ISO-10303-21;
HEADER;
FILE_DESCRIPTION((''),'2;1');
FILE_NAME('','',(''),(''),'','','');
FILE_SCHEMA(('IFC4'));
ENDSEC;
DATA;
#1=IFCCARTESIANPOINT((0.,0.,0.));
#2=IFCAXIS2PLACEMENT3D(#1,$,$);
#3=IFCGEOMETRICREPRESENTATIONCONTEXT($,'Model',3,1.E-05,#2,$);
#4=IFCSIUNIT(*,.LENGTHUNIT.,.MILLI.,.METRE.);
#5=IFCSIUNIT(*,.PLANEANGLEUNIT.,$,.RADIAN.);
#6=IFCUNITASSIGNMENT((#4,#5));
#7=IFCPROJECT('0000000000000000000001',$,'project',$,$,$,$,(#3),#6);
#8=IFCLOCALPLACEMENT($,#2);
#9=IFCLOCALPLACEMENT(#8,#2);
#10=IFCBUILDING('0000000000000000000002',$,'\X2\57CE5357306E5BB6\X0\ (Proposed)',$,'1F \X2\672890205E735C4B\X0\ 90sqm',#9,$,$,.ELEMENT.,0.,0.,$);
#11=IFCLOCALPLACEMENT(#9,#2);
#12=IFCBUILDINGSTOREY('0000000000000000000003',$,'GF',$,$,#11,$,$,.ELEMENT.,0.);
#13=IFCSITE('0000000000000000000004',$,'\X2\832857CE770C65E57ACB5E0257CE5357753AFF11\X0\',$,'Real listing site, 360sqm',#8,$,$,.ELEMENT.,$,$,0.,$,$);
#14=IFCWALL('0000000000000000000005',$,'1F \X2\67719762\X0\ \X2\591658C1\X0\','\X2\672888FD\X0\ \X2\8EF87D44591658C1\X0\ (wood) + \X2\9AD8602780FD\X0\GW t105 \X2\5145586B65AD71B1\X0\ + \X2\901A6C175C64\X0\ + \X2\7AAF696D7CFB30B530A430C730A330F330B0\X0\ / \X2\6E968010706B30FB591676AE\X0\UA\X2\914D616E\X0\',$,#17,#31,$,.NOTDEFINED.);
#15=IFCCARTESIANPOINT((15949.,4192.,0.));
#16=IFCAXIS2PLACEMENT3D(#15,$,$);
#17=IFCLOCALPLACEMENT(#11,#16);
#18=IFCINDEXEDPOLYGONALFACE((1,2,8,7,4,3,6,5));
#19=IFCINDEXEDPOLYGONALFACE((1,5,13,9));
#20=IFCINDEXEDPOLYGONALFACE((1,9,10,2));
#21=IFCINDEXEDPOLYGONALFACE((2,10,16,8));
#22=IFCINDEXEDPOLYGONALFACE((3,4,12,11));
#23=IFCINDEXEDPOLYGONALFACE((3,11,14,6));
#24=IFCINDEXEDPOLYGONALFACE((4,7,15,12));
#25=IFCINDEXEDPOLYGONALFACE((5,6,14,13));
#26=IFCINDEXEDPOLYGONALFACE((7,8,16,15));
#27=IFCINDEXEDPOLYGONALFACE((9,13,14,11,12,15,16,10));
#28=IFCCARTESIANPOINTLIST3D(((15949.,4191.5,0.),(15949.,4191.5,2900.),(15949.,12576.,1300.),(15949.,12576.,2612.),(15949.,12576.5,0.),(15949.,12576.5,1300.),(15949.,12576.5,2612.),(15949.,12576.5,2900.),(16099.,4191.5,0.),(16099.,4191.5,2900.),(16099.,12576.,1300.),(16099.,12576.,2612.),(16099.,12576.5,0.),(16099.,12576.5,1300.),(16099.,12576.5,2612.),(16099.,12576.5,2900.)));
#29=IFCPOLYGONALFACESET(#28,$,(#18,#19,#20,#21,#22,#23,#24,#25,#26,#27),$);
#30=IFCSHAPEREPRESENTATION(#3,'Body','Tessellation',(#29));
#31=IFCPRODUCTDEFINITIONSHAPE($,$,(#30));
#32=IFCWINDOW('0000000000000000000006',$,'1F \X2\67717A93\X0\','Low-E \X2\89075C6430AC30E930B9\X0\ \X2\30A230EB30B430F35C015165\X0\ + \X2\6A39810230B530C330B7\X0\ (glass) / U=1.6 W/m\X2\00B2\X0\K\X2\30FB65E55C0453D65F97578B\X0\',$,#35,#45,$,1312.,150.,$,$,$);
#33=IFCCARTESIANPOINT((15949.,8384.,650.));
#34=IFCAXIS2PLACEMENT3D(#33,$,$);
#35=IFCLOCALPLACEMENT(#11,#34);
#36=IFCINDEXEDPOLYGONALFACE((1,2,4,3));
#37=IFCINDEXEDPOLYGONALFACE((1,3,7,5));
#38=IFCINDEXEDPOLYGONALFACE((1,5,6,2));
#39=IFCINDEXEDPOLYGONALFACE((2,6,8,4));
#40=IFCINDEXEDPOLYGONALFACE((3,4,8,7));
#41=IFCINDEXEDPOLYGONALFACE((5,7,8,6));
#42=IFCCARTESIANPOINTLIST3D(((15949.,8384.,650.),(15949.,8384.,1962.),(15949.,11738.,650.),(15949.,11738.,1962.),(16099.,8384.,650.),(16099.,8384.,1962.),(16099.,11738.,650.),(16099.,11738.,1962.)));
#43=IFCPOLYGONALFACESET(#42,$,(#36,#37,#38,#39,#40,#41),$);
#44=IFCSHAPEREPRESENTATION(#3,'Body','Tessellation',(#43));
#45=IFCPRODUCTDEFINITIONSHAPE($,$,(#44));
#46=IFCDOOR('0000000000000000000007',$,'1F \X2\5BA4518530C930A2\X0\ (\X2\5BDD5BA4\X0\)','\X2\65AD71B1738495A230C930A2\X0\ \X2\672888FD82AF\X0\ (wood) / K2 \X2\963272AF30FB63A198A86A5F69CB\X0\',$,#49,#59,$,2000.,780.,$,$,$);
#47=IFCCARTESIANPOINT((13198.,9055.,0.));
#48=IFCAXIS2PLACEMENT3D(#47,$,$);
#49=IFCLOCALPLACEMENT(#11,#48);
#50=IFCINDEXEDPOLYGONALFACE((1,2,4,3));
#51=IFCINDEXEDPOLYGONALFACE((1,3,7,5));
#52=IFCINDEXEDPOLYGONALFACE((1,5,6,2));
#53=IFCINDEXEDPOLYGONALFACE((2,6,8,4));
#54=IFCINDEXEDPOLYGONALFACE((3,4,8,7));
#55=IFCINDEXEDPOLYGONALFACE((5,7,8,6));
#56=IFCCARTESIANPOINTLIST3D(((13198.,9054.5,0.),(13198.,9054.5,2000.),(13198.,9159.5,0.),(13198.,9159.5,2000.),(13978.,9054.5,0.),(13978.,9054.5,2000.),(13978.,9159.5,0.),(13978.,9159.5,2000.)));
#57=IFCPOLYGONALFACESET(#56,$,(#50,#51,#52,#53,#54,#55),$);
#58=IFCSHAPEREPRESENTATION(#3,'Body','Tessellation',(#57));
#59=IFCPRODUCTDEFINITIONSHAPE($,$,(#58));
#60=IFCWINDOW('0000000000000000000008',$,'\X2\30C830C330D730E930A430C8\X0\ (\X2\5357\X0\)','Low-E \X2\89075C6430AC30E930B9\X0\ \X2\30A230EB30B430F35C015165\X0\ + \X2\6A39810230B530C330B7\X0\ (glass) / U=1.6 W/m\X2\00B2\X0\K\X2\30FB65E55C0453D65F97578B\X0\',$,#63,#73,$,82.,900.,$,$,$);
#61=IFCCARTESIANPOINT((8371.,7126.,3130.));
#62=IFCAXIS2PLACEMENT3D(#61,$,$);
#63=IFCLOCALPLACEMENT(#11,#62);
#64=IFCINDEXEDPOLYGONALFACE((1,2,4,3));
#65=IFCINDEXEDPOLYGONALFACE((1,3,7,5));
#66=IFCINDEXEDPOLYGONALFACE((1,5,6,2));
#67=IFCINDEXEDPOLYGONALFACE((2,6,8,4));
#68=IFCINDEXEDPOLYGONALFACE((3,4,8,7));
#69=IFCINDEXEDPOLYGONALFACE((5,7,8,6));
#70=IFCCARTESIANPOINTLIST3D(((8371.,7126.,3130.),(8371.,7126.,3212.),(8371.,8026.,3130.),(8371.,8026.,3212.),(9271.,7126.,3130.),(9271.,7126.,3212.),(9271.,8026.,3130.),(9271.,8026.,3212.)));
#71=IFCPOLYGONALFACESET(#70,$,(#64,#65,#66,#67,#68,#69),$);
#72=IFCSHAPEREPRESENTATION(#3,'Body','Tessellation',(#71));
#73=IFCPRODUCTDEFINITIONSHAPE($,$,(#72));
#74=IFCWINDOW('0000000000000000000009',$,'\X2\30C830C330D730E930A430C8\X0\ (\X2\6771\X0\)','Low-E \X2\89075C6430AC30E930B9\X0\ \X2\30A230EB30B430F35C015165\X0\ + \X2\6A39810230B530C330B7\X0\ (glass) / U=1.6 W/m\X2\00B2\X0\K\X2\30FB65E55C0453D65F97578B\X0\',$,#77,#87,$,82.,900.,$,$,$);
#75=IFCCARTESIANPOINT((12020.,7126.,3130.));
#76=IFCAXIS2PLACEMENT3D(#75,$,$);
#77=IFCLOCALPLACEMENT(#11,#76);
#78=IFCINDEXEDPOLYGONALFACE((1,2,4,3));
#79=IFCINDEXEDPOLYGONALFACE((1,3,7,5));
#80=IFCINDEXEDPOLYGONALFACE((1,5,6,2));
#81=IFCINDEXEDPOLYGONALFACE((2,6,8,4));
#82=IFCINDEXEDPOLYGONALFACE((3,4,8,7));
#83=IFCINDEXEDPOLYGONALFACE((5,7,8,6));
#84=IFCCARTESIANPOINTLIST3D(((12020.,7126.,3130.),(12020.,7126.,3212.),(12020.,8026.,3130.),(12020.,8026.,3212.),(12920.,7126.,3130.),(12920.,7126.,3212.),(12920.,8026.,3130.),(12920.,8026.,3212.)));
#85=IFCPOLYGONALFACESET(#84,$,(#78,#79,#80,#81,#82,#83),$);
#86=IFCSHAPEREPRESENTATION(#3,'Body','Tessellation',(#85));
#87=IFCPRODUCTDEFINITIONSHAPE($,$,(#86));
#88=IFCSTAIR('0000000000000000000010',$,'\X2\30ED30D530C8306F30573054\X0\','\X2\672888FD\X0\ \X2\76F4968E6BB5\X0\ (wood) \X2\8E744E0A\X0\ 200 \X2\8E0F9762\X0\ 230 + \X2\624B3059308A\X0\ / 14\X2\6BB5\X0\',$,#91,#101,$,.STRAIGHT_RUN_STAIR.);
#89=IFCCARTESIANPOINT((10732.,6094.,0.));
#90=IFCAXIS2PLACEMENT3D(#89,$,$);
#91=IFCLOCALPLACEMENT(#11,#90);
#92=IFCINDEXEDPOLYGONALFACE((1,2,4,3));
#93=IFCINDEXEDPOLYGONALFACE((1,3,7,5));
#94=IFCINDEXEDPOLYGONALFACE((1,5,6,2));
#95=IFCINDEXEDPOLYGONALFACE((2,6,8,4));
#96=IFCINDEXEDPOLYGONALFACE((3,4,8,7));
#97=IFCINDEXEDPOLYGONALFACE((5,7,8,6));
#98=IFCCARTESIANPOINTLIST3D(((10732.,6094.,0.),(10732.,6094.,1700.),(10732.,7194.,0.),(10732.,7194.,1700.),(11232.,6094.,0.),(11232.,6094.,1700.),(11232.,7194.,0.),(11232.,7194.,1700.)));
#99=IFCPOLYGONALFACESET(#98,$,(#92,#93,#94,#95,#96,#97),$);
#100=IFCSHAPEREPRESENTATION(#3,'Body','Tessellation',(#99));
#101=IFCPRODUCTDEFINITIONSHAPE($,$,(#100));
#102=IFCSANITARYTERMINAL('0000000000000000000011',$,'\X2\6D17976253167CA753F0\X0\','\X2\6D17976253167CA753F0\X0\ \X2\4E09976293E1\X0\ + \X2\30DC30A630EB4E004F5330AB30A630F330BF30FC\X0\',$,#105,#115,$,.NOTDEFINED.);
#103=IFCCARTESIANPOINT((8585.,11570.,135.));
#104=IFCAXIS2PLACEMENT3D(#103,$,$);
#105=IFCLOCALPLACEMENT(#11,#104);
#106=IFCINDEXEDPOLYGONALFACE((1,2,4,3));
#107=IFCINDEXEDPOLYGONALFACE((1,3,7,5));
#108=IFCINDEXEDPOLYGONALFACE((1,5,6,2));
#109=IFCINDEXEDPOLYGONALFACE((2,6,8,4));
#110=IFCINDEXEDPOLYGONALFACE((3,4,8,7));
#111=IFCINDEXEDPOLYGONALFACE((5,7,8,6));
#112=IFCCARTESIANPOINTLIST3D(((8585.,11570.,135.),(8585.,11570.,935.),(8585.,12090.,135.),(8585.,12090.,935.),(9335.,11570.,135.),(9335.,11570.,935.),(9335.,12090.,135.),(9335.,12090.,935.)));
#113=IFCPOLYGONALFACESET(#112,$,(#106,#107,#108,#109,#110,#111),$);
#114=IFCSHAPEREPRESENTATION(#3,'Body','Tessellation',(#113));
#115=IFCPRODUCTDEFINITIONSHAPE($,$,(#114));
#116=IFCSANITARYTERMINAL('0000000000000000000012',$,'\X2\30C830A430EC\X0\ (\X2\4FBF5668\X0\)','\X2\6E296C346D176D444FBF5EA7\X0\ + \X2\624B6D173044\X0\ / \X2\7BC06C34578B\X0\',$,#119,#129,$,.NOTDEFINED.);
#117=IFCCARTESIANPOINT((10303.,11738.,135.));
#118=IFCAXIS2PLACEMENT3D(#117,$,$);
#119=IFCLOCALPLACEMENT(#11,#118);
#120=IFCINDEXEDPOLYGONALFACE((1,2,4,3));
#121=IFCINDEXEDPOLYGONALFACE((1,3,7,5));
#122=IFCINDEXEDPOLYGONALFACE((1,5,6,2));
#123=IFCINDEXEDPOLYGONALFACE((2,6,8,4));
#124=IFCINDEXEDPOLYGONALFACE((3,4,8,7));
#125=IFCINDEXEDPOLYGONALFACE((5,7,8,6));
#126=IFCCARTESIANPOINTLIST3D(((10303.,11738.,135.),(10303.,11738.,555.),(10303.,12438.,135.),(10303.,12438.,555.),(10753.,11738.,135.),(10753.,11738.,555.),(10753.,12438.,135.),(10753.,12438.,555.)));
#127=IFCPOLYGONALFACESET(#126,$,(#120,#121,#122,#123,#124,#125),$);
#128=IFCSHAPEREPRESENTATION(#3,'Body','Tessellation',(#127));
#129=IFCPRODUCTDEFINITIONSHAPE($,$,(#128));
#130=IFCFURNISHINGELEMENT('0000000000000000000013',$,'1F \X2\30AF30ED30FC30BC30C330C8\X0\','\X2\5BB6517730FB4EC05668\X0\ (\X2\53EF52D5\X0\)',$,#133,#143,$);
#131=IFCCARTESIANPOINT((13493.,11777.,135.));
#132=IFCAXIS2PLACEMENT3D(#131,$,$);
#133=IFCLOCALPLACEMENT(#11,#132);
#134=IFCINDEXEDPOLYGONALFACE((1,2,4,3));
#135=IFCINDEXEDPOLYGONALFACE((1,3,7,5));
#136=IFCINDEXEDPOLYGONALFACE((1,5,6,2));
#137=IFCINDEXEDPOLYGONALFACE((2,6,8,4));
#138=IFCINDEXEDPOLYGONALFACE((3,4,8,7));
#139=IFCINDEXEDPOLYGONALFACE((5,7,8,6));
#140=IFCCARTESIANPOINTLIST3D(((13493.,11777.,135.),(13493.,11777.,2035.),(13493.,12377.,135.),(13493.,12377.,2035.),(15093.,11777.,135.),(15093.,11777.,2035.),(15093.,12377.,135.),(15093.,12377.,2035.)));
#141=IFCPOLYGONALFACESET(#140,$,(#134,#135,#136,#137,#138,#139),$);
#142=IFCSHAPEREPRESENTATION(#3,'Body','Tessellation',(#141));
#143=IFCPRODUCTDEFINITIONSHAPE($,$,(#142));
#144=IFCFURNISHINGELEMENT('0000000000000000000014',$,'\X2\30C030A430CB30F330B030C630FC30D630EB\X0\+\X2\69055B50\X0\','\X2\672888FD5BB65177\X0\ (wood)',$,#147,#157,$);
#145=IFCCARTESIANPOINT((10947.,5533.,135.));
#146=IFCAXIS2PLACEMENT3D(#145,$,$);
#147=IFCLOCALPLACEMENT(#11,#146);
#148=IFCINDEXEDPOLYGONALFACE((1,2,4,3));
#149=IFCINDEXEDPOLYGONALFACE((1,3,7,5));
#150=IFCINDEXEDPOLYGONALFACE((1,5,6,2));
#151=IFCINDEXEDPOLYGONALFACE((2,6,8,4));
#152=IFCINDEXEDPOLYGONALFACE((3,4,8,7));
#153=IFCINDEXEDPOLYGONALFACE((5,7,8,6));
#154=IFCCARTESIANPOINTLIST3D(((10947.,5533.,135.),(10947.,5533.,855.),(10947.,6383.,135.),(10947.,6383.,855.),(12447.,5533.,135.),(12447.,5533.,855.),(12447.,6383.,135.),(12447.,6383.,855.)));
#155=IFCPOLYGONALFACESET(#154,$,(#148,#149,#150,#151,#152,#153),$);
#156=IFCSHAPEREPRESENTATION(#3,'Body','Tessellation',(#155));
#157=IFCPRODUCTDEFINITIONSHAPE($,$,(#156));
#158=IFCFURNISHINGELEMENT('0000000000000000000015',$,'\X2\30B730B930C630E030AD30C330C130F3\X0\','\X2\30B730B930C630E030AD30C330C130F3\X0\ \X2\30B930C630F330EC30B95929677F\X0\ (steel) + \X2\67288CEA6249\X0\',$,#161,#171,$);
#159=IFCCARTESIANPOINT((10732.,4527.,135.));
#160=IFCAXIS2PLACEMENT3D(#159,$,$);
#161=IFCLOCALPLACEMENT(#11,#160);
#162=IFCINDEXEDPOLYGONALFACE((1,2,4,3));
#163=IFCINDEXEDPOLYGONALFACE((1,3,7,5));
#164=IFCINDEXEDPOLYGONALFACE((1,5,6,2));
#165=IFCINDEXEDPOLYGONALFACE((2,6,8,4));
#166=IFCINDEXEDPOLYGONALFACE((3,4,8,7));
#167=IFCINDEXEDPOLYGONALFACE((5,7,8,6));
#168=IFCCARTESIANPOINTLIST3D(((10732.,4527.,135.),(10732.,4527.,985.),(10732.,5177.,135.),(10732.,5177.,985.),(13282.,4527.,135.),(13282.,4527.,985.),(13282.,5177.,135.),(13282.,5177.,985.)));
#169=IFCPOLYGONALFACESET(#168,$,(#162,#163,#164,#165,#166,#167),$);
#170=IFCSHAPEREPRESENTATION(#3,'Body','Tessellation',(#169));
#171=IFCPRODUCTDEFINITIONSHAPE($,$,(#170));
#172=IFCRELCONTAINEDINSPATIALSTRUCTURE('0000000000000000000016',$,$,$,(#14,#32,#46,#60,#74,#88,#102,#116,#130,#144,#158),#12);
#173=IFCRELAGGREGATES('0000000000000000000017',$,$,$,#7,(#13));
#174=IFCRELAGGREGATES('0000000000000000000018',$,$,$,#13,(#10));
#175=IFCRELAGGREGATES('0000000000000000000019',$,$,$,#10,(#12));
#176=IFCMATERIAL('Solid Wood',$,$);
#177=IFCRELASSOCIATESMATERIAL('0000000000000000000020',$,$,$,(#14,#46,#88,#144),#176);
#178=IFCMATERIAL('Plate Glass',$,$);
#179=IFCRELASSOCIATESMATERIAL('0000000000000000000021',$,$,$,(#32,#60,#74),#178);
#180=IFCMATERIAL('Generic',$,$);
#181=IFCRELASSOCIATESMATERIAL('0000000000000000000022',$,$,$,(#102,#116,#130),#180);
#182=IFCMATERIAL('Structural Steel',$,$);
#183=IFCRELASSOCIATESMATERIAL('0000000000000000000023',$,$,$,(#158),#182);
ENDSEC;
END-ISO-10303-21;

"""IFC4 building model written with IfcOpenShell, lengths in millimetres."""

from ifc_helpers import new_model, si_unit, frame, frame_2d, origin, place, context, project, spatial, rectangle, extrude, material, element, fill, save


model = new_model("IFC4")

# Units and contexts
model_context = context("Model", 3, precision=1e-05, world=origin())
ifc_project = project(units=[si_unit("LENGTHUNIT", "METRE", prefix="MILLI"), si_unit("PLANEANGLEUNIT", "RADIAN")], contexts=[model_context])

# Site, building, storey
site_placement = place(None, origin())
site = spatial("IfcSite", under=ifc_project, at=site_placement, Name="茨城県日立市城南町１", ObjectType="Real listing site, 360sqm", CompositionType="ELEMENT", RefElevation=0.0)
building_placement = place(site_placement, origin())
building = spatial("IfcBuilding", under=site, at=building_placement, Name="城南の家 (Proposed)", ObjectType="1F 木造平屋 90sqm", CompositionType="ELEMENT", ElevationOfRefHeight=0.0, ElevationOfTerrain=0.0)
storey_placement = place(building_placement, origin())
storey = spatial("IfcBuildingStorey", under=building, at=storey_placement, Name="GF", CompositionType="ELEMENT", Elevation=0.0)

# Wall, opening, window
ifc_material_1 = material(Name="Solid Wood")
wall_1_placement = place(storey_placement, frame((15949.0, 4192.0, 0.0)))
wall_1 = element("IfcWall", 1, at=wall_1_placement, inside=storey, material=ifc_material_1, Name="1F 東面 外壁", Description="木製 軸組外壁 (wood) + 高性能GW t105 充填断熱 + 通気層 + 窯業系サイディング / 準耐火・外皮UA配慮", PredefinedType="NOTDEFINED", context=model_context, shape_type="SweptSolid", body=[
    extrude(rectangle(XDim=150.0, YDim=8385.0, at=frame_2d((75.0, 4192.0))), frame((15949.0, 4192.0, 0.0)), (0.0, 0.0, 1.0), 2900.0),
])
opening_placement = place(storey_placement, frame((15949.0, 8384.0, 650.0)))
opening = element("IfcOpeningElement", 2, at=opening_placement, cuts=wall_1, PredefinedType="NOTDEFINED", context=model_context, shape_type="SweptSolid", body=[
    extrude(rectangle(XDim=150.0, YDim=3354.0, at=frame_2d((75.0, 1677.0))), frame((15949.0, 8384.0, 650.0)), (0.0, 0.0, 1.0), 1312.0),
])
ifc_material_2 = material(Name="Plate Glass")
window_1_placement = place(storey_placement, frame((15949.0, 8384.0, 650.0)))
window_1 = element("IfcWindow", 3, at=window_1_placement, inside=storey, material=ifc_material_2, Name="1F 東窓", Description="Low-E 複層ガラス アルゴン封入 + 樹脂サッシ (glass) / U=1.6 W/m²K・日射取得型", OverallHeight=1312.0, OverallWidth=150.0, context=model_context, shape_type="SweptSolid", body=[
    extrude(rectangle(XDim=150.0, YDim=3354.0, at=frame_2d((75.0, 1677.0))), frame((15949.0, 8384.0, 650.0)), (0.0, 0.0, 1.0), 1312.0),
])
fill(opening, window_1)

# Door
door_placement = place(storey_placement, frame((13198.0, 9055.0, 0.0)))
element("IfcDoor", 4, at=door_placement, inside=storey, material=ifc_material_1, Name="1F 室内ドア (寝室)", Description="断熱玄関ドア 木製芯 (wood) / K2 防犯・採風機構", OverallHeight=2000.0, OverallWidth=780.0, context=model_context, shape_type="SweptSolid", body=[
    extrude(rectangle(XDim=780.0, YDim=105.0, at=frame_2d((390.0, 52.0))), frame((13198.0, 9055.0, 0.0)), (0.0, 0.0, 1.0), 2000.0),
])

# Windows
window_2_placement = place(storey_placement, frame((8371.0, 7126.0, 3130.0)))
element("IfcWindow", 5, at=window_2_placement, inside=storey, material=ifc_material_2, Name="トップライト (南)", Description="Low-E 複層ガラス アルゴン封入 + 樹脂サッシ (glass) / U=1.6 W/m²K・日射取得型", OverallHeight=82.0, OverallWidth=900.0, context=model_context, shape_type="SweptSolid", body=[
    extrude(rectangle(XDim=900.0, YDim=900.0, at=frame_2d((450.0, 450.0))), frame((8371.0, 7126.0, 3130.0)), (0.0, 0.0, 1.0), 82.0),
])
window_3_placement = place(storey_placement, frame((12020.0, 7126.0, 3130.0)))
element("IfcWindow", 6, at=window_3_placement, inside=storey, material=ifc_material_2, Name="トップライト (東)", Description="Low-E 複層ガラス アルゴン封入 + 樹脂サッシ (glass) / U=1.6 W/m²K・日射取得型", OverallHeight=82.0, OverallWidth=900.0, context=model_context, shape_type="SweptSolid", body=[
    extrude(rectangle(XDim=900.0, YDim=900.0, at=frame_2d((450.0, 450.0))), frame((12020.0, 7126.0, 3130.0)), (0.0, 0.0, 1.0), 82.0),
])

# Stair
stair_placement = place(storey_placement, frame((10732.0, 6094.0, 0.0)))
element("IfcStair", 7, at=stair_placement, inside=storey, material=ifc_material_1, Name="ロフトはしご", Description="木製 直階段 (wood) 蹴上 200 踏面 230 + 手すり / 14段", PredefinedType="STRAIGHT_RUN_STAIR", context=model_context, shape_type="SweptSolid", body=[
    extrude(rectangle(XDim=500.0, YDim=1100.0, at=frame_2d((250.0, 550.0))), frame((10732.0, 6094.0, 0.0)), (0.0, 0.0, 1.0), 1700.0),
])

# Sanitary terminals
ifc_material_3 = material(Name="Generic")
sanitary_terminal_1_placement = place(storey_placement, frame((8585.0, 11570.0, 135.0)))
element("IfcSanitaryTerminal", 8, at=sanitary_terminal_1_placement, inside=storey, material=ifc_material_3, Name="洗面化粧台", Description="洗面化粧台 三面鏡 + ボウル一体カウンター", PredefinedType="NOTDEFINED", context=model_context, shape_type="SweptSolid", body=[
    extrude(rectangle(XDim=750.0, YDim=520.0, at=frame_2d((375.0, 260.0))), frame((8585.0, 11570.0, 135.0)), (0.0, 0.0, 1.0), 800.0),
])
sanitary_terminal_2_placement = place(storey_placement, frame((10303.0, 11738.0, 135.0)))
element("IfcSanitaryTerminal", 9, at=sanitary_terminal_2_placement, inside=storey, material=ifc_material_3, Name="トイレ (便器)", Description="温水洗浄便座 + 手洗い / 節水型", PredefinedType="NOTDEFINED", context=model_context, shape_type="SweptSolid", body=[
    extrude(rectangle(XDim=450.0, YDim=700.0, at=frame_2d((225.0, 350.0))), frame((10303.0, 11738.0, 135.0)), (0.0, 0.0, 1.0), 420.0),
])

# Furnishing elements
furnishing_1_placement = place(storey_placement, frame((13493.0, 11777.0, 135.0)))
element("IfcFurnishingElement", 10, at=furnishing_1_placement, inside=storey, material=ifc_material_3, Name="1F クローゼット", Description="家具・什器 (可動)", context=model_context, shape_type="SweptSolid", body=[
    extrude(rectangle(XDim=1600.0, YDim=600.0, at=frame_2d((800.0, 300.0))), frame((13493.0, 11777.0, 135.0)), (0.0, 0.0, 1.0), 1900.0),
])
furnishing_2_placement = place(storey_placement, frame((10947.0, 5533.0, 135.0)))
element("IfcFurnishingElement", 11, at=furnishing_2_placement, inside=storey, material=ifc_material_1, Name="ダイニングテーブル+椅子", Description="木製家具 (wood)", context=model_context, shape_type="SweptSolid", body=[
    extrude(rectangle(XDim=1500.0, YDim=850.0, at=frame_2d((750.0, 425.0))), frame((10947.0, 5533.0, 135.0)), (0.0, 0.0, 1.0), 720.0),
])
ifc_material_4 = material(Name="Structural Steel")
furnishing_3_placement = place(storey_placement, frame((10732.0, 4527.0, 135.0)))
element("IfcFurnishingElement", 12, at=furnishing_3_placement, inside=storey, material=ifc_material_4, Name="システムキッチン", Description="システムキッチン ステンレス天板 (steel) + 木質扉", context=model_context, shape_type="SweptSolid", body=[
    extrude(rectangle(XDim=2550.0, YDim=650.0, at=frame_2d((1275.0, 325.0))), frame((10732.0, 4527.0, 135.0)), (0.0, 0.0, 1.0), 850.0),
])

save(model, "model.ifc")
